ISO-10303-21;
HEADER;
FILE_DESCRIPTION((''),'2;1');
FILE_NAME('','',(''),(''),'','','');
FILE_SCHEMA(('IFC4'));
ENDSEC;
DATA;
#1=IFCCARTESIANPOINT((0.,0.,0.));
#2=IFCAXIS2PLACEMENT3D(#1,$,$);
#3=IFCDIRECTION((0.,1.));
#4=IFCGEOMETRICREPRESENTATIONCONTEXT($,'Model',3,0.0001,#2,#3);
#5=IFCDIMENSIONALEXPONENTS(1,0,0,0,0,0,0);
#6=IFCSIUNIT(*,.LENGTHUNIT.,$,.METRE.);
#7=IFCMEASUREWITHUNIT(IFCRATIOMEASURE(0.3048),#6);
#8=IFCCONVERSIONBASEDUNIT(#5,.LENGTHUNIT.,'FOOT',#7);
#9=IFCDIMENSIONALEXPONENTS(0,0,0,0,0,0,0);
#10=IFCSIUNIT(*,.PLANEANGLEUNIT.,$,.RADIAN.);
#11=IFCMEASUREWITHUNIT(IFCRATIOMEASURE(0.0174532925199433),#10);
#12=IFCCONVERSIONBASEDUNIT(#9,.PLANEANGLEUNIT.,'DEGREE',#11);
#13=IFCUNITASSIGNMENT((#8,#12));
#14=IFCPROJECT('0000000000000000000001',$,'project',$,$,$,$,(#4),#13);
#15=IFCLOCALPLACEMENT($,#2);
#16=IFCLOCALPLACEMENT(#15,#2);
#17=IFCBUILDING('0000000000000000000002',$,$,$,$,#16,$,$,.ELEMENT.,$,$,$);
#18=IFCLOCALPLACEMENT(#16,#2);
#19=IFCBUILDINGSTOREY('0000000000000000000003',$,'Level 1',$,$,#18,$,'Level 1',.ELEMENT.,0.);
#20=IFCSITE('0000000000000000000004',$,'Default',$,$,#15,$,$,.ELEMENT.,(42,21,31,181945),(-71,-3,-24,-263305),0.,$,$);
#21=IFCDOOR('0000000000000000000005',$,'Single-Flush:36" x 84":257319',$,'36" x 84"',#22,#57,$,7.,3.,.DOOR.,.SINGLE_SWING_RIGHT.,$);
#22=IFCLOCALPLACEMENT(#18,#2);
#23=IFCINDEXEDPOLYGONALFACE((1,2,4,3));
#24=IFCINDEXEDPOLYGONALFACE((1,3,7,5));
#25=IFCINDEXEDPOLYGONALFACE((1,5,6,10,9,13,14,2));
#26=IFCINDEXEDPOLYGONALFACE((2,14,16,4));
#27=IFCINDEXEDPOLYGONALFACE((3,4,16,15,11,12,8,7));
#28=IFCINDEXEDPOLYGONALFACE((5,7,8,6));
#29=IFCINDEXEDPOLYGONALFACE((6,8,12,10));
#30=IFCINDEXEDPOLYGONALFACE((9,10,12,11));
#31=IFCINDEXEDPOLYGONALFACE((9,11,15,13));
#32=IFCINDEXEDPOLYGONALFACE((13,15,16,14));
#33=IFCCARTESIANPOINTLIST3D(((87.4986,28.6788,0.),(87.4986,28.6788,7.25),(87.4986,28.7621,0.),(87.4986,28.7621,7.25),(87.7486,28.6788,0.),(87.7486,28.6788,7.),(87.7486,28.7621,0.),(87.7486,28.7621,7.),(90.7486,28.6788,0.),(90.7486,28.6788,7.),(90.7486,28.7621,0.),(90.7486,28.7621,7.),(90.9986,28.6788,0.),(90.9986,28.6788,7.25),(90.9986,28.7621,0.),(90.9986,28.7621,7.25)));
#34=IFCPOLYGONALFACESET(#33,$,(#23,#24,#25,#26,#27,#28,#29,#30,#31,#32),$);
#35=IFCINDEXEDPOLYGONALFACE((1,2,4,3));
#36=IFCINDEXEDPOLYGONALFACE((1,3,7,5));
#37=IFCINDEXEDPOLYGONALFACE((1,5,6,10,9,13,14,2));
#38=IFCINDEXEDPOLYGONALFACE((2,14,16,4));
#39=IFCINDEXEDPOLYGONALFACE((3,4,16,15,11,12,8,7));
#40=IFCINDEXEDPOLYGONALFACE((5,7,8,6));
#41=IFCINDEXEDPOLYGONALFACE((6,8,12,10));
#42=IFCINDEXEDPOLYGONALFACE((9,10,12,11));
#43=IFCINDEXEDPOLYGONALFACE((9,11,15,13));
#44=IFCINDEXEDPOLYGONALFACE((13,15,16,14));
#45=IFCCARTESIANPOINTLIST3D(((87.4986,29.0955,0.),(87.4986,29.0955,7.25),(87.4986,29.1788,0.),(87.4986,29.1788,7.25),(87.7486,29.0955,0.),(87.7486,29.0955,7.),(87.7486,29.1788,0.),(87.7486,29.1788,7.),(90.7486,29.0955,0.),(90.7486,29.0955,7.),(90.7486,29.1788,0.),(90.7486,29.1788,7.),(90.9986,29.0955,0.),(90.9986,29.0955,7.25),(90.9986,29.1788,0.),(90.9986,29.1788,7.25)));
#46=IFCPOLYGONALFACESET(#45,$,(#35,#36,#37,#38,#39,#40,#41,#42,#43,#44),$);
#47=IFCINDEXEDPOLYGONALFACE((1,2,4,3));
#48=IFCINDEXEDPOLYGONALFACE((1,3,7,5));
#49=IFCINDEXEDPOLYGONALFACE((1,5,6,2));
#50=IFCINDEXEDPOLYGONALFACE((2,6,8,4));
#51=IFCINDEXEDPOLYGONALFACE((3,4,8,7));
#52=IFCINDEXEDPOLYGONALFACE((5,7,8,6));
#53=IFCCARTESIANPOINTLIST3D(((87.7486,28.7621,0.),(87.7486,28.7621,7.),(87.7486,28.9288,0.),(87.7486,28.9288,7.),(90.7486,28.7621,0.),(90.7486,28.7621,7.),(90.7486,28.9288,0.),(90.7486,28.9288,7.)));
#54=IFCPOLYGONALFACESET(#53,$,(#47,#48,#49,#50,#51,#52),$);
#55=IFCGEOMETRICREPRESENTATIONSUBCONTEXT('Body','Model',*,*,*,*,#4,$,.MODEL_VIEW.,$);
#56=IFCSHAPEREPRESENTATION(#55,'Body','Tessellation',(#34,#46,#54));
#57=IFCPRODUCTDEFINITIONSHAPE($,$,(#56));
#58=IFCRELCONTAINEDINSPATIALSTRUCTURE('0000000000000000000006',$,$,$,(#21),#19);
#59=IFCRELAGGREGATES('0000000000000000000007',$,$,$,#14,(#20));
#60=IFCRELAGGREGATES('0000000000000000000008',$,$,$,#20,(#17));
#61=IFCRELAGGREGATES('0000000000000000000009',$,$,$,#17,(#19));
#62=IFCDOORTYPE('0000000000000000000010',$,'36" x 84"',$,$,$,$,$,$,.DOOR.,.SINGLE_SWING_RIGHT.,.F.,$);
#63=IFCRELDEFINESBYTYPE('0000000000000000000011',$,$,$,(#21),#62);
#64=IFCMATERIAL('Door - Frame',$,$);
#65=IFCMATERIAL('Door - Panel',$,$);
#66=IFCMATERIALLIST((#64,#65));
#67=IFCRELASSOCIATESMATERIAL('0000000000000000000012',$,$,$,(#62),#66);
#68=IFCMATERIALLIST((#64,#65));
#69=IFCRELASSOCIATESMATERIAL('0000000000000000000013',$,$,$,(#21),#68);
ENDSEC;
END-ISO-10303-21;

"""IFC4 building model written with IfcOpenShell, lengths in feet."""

from ifc_helpers import new_model, entity, si_unit, converted_unit, direction, frame, frame_2d, origin, place, context, subcontext, project, spatial, polyline, rectangle, outline, extrude, source, transform, mapped, material, material_list, type_object, type_shapes, element, save


model = new_model("IFC4")

# Units and contexts
model_context = context("Model", 3, precision=0.0001, world=origin(), true_north=direction((0.0, 1.0)))
body_context = subcontext(model_context, "Body", "Model", "MODEL_VIEW")
ifc_project = project(units=[converted_unit("LENGTHUNIT", "FOOT", entity("IfcRatioMeasure", 0.3048), si_unit("LENGTHUNIT", "METRE"), dimensions=[1, 0, 0, 0, 0, 0, 0]), converted_unit("PLANEANGLEUNIT", "DEGREE", entity("IfcRatioMeasure", 0.0174532925199433), si_unit("PLANEANGLEUNIT", "RADIAN"), dimensions=[0, 0, 0, 0, 0, 0, 0])], contexts=[model_context])

# Site, building, storey
site_placement = place(None, origin())
site = spatial("IfcSite", under=ifc_project, at=site_placement, Name="Default", CompositionType="ELEMENT", RefLatitude=(42, 21, 31, 181945), RefLongitude=(-71, -3, -24, -263305), RefElevation=0.0)
building_placement = place(site_placement, origin())
building = spatial("IfcBuilding", under=site, at=building_placement, CompositionType="ELEMENT")
storey_placement = place(building_placement, origin())
storey = spatial("IfcBuildingStorey", under=building, at=storey_placement, Name="Level 1", LongName="Level 1", CompositionType="ELEMENT", Elevation=0.0)

# Shared definitions
placement_1 = place(storey_placement, frame((-0.1681, 28.9288, 0.0)))

# Door
ifc_material_1 = material(Name="Door - Frame")
ifc_material_2 = material(Name="Door - Panel")
ifc_material_list_1 = material_list([ifc_material_1, ifc_material_2])
ifc_material_list_2 = material_list([ifc_material_1, ifc_material_2])
door_type = type_object("IfcDoorType", Name="36\" x 84\"", OperationType="SINGLE_SWING_RIGHT", ParameterTakesPrecedence=False, PredefinedType="DOOR", material=ifc_material_list_2)
shared_shape = source(origin(), body_context, "Body", "SweptSolid", [
    extrude(outline(polyline([(-1.75, -3.6875), (1.75, -3.6875), (1.75, 3.5625), (1.5, 3.5625), (1.5, -3.4375), (-1.5, -3.4375), (-1.5, 3.5625), (-1.75, 3.5625), (-1.75, -3.6875)])), frame((1.5, 0.3333, 3.5625), z_axis=(0.0, 1.0, 0.0), x_axis=(1.0, 0.0, 0.0)), (0.0, 0.0, 1.0), 0.0833),
    extrude(outline(polyline([(-3.6875, -1.75), (3.5625, -1.75), (3.5625, -1.5), (-3.4375, -1.5), (-3.4375, 1.5), (3.5625, 1.5), (3.5625, 1.75), (-3.6875, 1.75), (-3.6875, -1.75)])), frame((1.5, -0.0833, 3.5625), z_axis=(0.0, 1.0, 0.0), x_axis=(0.0, 0.0, -1.0)), (0.0, 0.0, 1.0), 0.0833),
    extrude(rectangle(XDim=0.1667, YDim=3.0, at=frame_2d((0.0, 0.0), x_axis=(1.0, 0.0))), frame((1.5, 0.25, 0.0), z_axis=(0.0, 0.0, 1.0), x_axis=(0.0, 1.0, 0.0)), (0.0, 0.0, 1.0), 7.0),
])
type_shapes(door_type, [shared_shape])
placement_2 = place(placement_1, frame((90.9167, 0.1667, 0.0)))
door_placement = place(placement_2, frame((0.0, 0.0, 0.0), z_axis=(0.0, 0.0, 1.0), x_axis=(-1.0, 0.0, 0.0)))
element("IfcDoor", 1, at=door_placement, inside=storey, type_object=door_type, material=ifc_material_list_1, Name="Single-Flush:36\" x 84\":257319", ObjectType="36\" x 84\"", OperationType="SINGLE_SWING_RIGHT", OverallHeight=7.0, OverallWidth=3.0, PredefinedType="DOOR", context=body_context, shape_type="MappedRepresentation", body=[
    mapped(shared_shape, transform((0.0, 0.0, 0.0), scale=1.0)),
])

save(model, "model.ifc")
